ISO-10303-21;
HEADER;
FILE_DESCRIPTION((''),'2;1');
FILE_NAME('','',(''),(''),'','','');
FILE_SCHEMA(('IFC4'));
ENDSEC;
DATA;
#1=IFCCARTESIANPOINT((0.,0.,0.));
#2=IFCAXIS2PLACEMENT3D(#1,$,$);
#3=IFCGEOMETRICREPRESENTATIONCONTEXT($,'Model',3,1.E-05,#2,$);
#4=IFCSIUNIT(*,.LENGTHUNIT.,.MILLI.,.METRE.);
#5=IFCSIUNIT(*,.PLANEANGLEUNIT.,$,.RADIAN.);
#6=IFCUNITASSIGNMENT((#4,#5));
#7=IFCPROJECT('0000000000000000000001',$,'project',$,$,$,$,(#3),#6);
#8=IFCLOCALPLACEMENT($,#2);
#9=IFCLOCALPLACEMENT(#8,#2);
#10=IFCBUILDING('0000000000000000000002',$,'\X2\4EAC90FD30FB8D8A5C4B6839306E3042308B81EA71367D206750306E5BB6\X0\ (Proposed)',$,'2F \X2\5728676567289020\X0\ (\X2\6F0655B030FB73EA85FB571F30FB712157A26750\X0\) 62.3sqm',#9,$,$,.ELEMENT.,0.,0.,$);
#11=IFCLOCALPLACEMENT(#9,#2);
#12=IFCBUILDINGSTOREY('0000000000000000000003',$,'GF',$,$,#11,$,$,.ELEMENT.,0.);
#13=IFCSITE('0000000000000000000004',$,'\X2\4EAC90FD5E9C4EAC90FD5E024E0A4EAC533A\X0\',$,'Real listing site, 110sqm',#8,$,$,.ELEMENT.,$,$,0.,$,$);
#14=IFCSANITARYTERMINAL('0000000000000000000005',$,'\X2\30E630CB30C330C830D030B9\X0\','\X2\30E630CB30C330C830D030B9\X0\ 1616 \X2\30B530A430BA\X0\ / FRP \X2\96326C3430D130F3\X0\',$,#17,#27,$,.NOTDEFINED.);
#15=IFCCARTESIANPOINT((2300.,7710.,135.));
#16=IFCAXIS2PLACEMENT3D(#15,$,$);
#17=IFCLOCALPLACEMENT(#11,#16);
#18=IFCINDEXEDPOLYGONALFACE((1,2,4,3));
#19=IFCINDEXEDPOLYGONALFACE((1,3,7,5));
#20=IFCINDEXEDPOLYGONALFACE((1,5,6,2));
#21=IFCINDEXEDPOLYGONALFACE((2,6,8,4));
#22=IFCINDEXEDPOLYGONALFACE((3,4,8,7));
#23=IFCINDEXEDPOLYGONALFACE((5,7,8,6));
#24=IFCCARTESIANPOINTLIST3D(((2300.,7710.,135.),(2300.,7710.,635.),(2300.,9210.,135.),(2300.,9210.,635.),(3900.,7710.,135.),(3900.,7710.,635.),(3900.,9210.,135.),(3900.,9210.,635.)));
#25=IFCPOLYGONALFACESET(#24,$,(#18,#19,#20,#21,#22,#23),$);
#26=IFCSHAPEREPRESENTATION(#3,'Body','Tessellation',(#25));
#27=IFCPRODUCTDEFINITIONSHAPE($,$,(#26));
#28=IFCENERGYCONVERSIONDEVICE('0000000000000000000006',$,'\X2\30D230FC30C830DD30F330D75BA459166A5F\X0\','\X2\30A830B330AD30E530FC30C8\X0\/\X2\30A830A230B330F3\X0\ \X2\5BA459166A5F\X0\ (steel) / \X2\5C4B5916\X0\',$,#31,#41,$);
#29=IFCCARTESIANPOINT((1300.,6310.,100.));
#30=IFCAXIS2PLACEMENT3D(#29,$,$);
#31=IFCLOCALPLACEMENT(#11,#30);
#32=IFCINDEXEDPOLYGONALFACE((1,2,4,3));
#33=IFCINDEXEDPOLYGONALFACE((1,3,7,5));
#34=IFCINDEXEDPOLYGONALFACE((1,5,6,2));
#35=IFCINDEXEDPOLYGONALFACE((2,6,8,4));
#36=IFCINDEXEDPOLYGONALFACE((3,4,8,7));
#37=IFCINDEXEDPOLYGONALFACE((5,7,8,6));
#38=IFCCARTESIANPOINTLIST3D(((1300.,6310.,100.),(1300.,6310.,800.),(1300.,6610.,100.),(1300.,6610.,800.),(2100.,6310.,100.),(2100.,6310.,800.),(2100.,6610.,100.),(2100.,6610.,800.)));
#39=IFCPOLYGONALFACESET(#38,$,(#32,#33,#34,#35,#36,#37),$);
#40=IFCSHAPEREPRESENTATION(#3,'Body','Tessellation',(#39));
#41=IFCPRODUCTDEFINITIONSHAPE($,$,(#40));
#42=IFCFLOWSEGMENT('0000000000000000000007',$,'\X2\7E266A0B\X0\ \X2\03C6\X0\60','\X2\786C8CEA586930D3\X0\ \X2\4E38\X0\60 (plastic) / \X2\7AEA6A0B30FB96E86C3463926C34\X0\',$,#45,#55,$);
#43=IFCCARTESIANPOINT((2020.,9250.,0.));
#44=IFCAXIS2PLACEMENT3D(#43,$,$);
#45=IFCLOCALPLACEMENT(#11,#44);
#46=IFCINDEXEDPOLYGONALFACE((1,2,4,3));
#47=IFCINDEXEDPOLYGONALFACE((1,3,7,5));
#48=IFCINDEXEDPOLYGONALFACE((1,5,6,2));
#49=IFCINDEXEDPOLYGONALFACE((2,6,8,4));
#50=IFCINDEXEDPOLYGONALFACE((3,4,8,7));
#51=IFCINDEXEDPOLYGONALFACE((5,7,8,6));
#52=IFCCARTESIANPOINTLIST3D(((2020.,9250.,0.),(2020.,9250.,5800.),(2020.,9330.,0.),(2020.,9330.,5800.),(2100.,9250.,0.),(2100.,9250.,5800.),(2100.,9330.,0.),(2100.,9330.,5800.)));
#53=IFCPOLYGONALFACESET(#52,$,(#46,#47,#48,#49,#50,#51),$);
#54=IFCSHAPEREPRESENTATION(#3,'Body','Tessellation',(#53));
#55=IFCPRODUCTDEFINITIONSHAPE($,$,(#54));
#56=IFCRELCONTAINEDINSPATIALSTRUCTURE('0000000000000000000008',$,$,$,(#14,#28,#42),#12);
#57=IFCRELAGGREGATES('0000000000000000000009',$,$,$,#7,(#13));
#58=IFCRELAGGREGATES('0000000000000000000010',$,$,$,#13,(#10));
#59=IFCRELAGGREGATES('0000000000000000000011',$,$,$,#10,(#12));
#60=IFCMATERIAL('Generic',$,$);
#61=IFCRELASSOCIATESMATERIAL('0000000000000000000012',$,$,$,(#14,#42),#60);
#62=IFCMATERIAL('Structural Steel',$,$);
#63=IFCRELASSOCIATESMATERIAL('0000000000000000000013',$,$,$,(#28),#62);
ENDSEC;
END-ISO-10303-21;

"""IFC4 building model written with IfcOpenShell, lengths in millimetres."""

from ifc_helpers import new_model, si_unit, frame, frame_2d, origin, place, context, project, spatial, rectangle, extrude, material, element, save


model = new_model("IFC4")

# Units and contexts
model_context = context("Model", 3, precision=1e-05, world=origin())
ifc_project = project(units=[si_unit("LENGTHUNIT", "METRE", prefix="MILLI"), si_unit("PLANEANGLEUNIT", "RADIAN")], contexts=[model_context])

# Site, building, storey
site_placement = place(None, origin())
site = spatial("IfcSite", under=ifc_project, at=site_placement, Name="京都府京都市上京区", ObjectType="Real listing site, 110sqm", CompositionType="ELEMENT", RefElevation=0.0)
building_placement = place(site_placement, origin())
building = spatial("IfcBuilding", under=site, at=building_placement, Name="京都・越屋根のある自然素材の家 (Proposed)", ObjectType="2F 在来木造 (漆喰・珪藻土・無垢材) 62.3sqm", CompositionType="ELEMENT", ElevationOfRefHeight=0.0, ElevationOfTerrain=0.0)
storey_placement = place(building_placement, origin())
storey = spatial("IfcBuildingStorey", under=building, at=storey_placement, Name="GF", CompositionType="ELEMENT", Elevation=0.0)

# Shared definitions
ifc_material_1 = material(Name="Generic")

# Sanitary terminal
sanitary_terminal_placement = place(storey_placement, frame((2300.0, 7710.0, 135.0)))
element("IfcSanitaryTerminal", 1, at=sanitary_terminal_placement, inside=storey, material=ifc_material_1, Name="ユニットバス", Description="ユニットバス 1616 サイズ / FRP 防水パン", PredefinedType="NOTDEFINED", context=model_context, shape_type="SweptSolid", body=[
    extrude(rectangle(XDim=1600.0, YDim=1500.0, at=frame_2d((800.0, 750.0))), frame((2300.0, 7710.0, 135.0)), (0.0, 0.0, 1.0), 500.0),
])

# Energy conversion device
ifc_material_2 = material(Name="Structural Steel")
energy_conversion_device_placement = place(storey_placement, frame((1300.0, 6310.0, 100.0)))
element("IfcEnergyConversionDevice", 2, at=energy_conversion_device_placement, inside=storey, material=ifc_material_2, Name="ヒートポンプ室外機", Description="エコキュート/エアコン 室外機 (steel) / 屋外", context=model_context, shape_type="SweptSolid", body=[
    extrude(rectangle(XDim=800.0, YDim=300.0, at=frame_2d((400.0, 150.0))), frame((1300.0, 6310.0, 100.0)), (0.0, 0.0, 1.0), 700.0),
])

# Flow segment
flow_segment_placement = place(storey_placement, frame((2020.0, 9250.0, 0.0)))
element("IfcFlowSegment", 3, at=flow_segment_placement, inside=storey, material=ifc_material_1, Name="縦樋 φ60", Description="硬質塩ビ 丸60 (plastic) / 竪樋・雨水排水", context=model_context, shape_type="SweptSolid", body=[
    extrude(rectangle(XDim=80.0, YDim=80.0, at=frame_2d((40.0, 40.0))), frame((2020.0, 9250.0, 0.0)), (0.0, 0.0, 1.0), 5800.0),
])

save(model, "model.ifc")
